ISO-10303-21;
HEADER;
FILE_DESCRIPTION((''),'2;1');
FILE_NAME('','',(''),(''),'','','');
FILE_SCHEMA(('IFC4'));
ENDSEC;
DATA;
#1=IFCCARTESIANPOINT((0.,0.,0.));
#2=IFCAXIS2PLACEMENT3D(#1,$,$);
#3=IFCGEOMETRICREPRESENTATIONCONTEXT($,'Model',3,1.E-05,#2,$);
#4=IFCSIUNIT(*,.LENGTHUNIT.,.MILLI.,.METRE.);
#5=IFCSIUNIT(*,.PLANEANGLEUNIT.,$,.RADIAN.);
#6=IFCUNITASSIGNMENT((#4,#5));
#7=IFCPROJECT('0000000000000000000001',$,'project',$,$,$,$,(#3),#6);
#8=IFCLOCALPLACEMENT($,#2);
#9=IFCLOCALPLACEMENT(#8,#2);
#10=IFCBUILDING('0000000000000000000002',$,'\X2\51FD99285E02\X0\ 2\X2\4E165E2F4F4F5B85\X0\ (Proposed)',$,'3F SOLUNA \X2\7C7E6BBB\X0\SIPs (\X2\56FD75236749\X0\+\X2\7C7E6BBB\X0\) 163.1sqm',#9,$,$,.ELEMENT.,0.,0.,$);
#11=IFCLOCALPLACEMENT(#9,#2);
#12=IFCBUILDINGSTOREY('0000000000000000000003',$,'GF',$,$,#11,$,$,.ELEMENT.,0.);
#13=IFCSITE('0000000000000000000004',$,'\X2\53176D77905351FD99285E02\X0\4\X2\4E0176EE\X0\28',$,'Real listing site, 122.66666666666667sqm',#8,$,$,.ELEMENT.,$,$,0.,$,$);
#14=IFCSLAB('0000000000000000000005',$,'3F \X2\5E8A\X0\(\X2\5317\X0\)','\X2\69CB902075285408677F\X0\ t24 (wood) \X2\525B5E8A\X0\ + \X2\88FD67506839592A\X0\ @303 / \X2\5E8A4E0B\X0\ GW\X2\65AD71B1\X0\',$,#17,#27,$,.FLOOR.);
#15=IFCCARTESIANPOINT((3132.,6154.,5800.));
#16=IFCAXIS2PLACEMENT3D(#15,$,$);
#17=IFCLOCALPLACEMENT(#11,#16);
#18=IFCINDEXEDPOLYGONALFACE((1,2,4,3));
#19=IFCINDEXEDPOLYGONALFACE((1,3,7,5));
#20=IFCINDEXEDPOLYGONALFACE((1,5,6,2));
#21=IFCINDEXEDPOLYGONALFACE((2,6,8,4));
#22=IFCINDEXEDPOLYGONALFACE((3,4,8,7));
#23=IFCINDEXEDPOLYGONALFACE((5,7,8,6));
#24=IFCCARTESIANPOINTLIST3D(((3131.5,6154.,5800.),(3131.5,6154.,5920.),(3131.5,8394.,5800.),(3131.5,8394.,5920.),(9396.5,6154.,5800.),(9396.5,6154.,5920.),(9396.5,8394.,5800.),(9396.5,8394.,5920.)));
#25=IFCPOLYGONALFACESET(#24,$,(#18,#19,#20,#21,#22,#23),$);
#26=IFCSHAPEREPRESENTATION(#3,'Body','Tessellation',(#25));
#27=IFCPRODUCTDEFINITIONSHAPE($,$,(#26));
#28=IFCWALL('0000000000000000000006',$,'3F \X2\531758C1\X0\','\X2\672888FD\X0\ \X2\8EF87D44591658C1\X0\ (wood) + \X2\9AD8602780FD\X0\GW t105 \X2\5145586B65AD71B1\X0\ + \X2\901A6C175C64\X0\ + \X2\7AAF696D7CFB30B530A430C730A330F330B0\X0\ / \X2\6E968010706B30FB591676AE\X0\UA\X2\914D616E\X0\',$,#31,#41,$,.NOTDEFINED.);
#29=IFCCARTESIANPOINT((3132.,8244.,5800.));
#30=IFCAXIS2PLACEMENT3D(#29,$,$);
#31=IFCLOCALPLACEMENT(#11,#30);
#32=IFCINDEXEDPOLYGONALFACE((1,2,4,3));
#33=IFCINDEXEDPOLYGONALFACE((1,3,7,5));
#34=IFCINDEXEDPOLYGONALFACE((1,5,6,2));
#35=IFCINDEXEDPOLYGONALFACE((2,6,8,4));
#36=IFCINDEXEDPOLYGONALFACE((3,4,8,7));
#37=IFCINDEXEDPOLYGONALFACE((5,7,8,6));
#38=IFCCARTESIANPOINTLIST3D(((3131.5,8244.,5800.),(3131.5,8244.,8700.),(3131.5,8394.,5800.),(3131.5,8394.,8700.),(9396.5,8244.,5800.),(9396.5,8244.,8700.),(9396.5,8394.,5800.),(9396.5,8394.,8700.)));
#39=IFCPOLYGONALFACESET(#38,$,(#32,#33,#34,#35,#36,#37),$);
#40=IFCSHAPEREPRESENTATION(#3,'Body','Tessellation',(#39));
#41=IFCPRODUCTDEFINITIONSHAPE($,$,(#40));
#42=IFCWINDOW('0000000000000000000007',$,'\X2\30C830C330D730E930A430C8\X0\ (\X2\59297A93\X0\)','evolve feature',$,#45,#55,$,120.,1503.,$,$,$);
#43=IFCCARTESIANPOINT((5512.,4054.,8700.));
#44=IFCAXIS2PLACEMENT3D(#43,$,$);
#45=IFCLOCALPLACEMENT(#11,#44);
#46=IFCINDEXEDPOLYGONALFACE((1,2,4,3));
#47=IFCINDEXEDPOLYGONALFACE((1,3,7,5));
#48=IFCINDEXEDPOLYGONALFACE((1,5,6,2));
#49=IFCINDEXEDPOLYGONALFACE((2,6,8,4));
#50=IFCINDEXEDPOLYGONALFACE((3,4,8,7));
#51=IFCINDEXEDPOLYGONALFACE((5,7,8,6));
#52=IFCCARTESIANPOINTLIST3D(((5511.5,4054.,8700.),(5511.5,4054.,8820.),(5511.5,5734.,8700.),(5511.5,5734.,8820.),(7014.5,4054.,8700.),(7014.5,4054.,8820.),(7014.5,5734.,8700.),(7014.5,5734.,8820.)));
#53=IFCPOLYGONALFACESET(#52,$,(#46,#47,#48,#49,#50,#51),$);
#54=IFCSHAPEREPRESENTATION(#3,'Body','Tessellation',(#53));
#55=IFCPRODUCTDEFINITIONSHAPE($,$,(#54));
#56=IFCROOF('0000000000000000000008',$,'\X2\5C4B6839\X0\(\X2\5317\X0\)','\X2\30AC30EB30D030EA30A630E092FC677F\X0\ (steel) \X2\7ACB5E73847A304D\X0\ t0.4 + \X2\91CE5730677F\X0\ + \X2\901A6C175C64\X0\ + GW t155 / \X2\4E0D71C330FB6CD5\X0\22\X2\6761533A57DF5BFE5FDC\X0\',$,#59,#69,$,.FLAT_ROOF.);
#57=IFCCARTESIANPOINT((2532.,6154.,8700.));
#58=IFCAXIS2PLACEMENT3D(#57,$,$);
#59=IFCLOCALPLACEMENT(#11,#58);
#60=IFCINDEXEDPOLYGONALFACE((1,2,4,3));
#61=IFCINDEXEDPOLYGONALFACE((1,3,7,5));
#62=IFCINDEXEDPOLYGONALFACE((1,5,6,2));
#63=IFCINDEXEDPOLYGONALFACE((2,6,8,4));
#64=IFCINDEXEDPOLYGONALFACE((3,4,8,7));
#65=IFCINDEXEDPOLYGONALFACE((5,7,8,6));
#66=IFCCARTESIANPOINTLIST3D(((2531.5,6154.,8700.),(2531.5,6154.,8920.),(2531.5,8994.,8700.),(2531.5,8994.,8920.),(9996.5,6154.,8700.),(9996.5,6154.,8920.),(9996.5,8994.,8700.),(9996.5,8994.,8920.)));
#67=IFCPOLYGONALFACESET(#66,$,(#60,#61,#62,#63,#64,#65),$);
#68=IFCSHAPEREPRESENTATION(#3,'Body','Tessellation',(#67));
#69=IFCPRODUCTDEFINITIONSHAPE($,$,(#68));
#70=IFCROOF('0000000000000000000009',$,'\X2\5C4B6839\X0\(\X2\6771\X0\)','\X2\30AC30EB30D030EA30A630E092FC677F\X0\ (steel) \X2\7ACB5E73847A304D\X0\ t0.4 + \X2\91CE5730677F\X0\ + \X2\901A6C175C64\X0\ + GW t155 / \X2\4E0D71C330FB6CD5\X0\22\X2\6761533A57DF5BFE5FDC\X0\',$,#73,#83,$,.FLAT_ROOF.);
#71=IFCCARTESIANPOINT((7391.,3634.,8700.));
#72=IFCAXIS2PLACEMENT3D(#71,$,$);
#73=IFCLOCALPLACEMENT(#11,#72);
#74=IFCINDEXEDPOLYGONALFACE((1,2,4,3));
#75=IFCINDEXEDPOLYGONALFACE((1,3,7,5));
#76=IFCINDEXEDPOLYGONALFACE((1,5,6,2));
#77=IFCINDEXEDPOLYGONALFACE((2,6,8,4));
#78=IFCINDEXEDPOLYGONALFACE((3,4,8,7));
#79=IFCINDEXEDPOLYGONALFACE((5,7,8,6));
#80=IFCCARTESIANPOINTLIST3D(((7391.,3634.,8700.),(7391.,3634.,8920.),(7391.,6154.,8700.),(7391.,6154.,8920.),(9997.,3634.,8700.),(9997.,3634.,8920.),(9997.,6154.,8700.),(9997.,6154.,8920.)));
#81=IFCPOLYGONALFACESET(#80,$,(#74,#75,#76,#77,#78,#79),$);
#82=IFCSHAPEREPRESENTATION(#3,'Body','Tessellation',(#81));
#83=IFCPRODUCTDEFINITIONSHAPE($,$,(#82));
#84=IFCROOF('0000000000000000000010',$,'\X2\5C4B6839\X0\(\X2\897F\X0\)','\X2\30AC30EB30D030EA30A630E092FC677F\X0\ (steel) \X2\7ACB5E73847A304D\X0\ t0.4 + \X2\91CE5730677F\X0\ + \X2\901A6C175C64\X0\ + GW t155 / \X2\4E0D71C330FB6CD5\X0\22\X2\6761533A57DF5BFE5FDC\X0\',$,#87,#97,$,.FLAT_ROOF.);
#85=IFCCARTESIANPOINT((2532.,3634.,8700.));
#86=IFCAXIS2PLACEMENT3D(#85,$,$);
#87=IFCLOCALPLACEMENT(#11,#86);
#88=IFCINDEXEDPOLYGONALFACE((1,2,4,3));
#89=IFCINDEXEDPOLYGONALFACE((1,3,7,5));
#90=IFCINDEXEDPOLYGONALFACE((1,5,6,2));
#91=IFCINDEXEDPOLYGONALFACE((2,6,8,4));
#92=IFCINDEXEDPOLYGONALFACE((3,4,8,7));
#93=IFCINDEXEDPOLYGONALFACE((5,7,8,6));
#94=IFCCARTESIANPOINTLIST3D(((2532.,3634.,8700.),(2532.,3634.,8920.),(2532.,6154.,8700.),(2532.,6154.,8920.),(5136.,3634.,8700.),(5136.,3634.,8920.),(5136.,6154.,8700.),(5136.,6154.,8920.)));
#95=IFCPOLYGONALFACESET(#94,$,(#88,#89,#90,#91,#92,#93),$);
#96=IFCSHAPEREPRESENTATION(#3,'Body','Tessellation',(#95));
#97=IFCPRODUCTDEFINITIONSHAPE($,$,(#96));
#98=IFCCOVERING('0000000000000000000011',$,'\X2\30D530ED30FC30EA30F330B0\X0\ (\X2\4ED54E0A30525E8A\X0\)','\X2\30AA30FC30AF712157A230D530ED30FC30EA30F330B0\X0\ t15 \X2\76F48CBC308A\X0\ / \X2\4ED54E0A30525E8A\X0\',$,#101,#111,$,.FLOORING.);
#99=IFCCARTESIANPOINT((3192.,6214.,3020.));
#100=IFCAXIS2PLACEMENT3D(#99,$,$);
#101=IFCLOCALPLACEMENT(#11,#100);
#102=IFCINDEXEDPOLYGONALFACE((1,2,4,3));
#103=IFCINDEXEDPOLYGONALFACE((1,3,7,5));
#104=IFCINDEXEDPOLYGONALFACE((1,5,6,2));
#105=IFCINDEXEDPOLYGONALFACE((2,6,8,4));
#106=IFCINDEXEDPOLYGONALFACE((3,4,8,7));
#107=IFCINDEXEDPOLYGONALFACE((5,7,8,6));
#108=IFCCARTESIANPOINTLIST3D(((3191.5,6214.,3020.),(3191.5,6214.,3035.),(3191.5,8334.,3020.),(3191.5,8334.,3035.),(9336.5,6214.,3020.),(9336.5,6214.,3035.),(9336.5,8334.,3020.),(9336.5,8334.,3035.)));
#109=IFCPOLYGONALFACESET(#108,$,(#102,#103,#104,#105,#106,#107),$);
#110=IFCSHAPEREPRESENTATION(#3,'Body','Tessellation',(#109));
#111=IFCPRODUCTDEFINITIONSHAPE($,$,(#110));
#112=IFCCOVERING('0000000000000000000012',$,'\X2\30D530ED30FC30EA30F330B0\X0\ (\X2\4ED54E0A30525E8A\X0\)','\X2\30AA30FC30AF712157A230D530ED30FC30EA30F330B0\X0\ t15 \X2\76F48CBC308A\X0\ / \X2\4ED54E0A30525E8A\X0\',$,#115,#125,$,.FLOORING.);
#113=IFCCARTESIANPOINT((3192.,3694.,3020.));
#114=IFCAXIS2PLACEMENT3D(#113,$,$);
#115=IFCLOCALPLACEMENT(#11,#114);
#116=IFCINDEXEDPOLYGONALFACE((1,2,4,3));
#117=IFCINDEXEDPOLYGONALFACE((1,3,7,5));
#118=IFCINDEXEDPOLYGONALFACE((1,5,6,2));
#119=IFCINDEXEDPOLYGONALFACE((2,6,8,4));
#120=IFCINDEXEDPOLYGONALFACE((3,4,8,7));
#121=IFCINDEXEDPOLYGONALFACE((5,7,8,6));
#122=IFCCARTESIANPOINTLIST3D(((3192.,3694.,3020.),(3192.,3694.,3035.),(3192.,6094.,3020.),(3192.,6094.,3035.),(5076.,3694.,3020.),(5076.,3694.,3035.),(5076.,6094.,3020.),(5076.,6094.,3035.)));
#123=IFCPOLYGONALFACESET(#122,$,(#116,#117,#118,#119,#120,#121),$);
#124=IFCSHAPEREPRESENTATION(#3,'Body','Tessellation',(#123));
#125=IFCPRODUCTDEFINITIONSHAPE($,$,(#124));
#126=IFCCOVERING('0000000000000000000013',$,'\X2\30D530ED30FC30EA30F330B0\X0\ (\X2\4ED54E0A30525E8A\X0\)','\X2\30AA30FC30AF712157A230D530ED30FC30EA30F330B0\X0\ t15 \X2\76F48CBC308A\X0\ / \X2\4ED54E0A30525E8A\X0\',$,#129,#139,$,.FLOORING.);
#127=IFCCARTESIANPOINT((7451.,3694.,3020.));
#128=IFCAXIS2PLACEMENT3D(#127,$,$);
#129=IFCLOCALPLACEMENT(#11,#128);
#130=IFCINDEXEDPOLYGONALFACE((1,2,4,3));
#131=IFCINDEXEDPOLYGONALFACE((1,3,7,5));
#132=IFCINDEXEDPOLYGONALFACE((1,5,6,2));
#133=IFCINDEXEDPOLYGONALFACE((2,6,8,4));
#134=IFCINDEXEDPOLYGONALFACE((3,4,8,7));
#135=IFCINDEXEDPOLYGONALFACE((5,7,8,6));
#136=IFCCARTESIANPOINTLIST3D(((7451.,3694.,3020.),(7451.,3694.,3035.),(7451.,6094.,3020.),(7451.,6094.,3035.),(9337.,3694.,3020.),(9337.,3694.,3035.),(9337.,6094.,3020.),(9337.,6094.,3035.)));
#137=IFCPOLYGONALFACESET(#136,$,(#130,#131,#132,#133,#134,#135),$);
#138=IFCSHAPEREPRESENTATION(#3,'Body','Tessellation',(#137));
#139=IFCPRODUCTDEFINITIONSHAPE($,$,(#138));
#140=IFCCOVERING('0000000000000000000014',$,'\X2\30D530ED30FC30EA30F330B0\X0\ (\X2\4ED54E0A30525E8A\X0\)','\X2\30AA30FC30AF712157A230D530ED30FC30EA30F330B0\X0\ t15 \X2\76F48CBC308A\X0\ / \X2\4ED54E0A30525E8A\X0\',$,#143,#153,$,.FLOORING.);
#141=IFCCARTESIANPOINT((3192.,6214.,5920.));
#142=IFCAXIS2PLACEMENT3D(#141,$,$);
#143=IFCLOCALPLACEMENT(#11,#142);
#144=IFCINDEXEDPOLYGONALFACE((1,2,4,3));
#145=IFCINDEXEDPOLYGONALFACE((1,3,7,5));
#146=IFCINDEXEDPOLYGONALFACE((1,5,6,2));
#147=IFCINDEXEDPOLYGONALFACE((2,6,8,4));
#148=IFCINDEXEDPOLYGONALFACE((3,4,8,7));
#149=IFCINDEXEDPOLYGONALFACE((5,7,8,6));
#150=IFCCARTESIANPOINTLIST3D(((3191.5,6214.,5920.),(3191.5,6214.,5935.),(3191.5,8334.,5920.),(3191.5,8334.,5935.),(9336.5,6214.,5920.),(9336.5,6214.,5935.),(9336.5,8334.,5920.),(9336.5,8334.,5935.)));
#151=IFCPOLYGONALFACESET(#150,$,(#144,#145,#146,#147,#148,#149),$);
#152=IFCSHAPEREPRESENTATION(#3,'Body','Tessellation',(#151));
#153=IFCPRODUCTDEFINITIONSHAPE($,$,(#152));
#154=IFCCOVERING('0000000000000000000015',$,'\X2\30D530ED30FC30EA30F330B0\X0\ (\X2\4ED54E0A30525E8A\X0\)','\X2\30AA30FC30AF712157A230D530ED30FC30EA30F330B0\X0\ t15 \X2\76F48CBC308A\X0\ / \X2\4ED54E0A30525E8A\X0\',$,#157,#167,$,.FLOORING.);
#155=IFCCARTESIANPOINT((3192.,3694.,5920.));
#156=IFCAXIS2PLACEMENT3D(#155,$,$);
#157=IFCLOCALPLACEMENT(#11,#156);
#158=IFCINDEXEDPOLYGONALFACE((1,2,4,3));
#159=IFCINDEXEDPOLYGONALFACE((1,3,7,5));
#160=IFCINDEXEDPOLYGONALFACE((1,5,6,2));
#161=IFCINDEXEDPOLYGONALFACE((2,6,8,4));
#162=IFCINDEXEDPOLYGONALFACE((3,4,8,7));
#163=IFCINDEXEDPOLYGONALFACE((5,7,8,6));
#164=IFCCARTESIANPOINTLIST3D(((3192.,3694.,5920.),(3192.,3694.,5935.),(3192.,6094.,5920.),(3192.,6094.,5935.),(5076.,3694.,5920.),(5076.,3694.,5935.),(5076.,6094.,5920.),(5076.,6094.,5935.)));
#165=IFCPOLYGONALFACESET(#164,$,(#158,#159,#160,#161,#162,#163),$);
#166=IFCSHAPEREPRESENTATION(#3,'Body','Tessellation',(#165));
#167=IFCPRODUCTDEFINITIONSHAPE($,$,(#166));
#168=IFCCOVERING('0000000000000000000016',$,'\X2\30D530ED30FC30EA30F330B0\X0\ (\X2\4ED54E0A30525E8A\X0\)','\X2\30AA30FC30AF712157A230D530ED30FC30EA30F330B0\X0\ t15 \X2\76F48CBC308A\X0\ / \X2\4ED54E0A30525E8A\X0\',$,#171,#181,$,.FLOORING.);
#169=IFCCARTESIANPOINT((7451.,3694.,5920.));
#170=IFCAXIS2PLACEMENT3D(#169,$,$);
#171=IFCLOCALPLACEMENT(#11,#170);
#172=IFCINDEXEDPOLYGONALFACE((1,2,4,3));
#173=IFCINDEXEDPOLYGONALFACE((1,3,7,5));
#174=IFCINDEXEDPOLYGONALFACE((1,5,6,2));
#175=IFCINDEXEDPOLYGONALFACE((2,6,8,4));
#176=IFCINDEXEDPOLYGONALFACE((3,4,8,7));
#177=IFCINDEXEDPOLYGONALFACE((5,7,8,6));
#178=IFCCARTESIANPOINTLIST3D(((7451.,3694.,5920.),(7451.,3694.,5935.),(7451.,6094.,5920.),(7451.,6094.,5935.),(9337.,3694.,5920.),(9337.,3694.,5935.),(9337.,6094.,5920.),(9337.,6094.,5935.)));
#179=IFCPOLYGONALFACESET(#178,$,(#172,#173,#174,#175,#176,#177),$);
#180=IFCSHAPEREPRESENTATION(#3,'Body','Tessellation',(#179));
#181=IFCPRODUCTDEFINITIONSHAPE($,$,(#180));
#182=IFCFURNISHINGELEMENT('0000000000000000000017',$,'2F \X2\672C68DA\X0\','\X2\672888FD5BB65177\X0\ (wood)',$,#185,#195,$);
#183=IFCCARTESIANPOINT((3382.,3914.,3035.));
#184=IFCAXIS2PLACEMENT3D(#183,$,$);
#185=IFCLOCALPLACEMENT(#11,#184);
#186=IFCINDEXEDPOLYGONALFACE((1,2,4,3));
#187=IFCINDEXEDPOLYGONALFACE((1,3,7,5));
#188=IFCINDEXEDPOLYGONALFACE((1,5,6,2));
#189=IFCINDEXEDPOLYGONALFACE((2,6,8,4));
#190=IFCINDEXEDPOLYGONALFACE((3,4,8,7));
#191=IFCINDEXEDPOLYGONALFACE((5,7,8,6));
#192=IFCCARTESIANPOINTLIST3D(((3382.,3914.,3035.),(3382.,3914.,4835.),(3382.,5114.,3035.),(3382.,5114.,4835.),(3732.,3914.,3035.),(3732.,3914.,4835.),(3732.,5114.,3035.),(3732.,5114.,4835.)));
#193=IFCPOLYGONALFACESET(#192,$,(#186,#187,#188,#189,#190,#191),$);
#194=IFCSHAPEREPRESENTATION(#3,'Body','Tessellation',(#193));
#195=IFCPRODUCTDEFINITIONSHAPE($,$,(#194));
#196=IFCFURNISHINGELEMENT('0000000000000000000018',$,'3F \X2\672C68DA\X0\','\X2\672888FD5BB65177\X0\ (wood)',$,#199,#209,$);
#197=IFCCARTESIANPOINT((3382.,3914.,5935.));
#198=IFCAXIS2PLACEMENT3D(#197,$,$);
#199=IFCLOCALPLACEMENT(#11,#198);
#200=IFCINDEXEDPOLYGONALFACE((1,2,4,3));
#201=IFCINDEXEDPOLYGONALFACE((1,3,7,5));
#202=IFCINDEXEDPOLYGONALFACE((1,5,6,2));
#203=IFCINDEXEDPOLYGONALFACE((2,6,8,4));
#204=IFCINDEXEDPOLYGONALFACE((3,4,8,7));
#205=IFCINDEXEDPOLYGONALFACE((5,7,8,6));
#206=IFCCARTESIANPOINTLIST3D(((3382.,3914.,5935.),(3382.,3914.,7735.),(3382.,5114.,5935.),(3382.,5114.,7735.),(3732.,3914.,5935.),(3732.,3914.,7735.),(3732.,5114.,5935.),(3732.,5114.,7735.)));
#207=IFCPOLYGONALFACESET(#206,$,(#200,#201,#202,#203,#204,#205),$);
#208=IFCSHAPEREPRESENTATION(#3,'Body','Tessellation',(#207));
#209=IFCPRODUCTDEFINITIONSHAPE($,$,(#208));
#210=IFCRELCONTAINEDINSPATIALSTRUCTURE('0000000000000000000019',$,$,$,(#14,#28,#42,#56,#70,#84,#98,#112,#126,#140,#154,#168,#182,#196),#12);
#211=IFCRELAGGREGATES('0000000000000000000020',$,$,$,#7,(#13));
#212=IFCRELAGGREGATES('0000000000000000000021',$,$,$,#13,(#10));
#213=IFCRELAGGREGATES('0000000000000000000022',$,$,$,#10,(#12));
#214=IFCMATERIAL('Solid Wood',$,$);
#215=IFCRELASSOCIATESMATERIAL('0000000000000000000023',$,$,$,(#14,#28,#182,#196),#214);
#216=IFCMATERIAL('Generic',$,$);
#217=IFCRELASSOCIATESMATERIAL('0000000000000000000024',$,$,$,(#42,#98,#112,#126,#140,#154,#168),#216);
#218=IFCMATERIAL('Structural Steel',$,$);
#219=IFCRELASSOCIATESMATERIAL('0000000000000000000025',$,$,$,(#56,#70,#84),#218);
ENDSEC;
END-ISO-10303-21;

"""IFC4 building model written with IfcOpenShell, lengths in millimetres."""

from ifc_helpers import new_model, si_unit, frame, frame_2d, origin, place, context, project, spatial, rectangle, extrude, material, element, save


model = new_model("IFC4")

# Units and contexts
model_context = context("Model", 3, precision=1e-05, world=origin())
ifc_project = project(units=[si_unit("LENGTHUNIT", "METRE", prefix="MILLI"), si_unit("PLANEANGLEUNIT", "RADIAN")], contexts=[model_context])

# Site, building, storey
site_placement = place(None, origin())
site = spatial("IfcSite", under=ifc_project, at=site_placement, Name="北海道函館市4丁目28", ObjectType="Real listing site, 122.66666666666667sqm", CompositionType="ELEMENT", RefElevation=0.0)
building_placement = place(site_placement, origin())
building = spatial("IfcBuilding", under=site, at=building_placement, Name="函館市 2世帯住宅 (Proposed)", ObjectType="3F SOLUNA 籾殻SIPs (国産杉+籾殻) 163.1sqm", CompositionType="ELEMENT", ElevationOfRefHeight=0.0, ElevationOfTerrain=0.0)
storey_placement = place(building_placement, origin())
storey = spatial("IfcBuildingStorey", under=building, at=storey_placement, Name="GF", CompositionType="ELEMENT", Elevation=0.0)

# Slab
ifc_material_1 = material(Name="Solid Wood")
slab_placement = place(storey_placement, frame((3132.0, 6154.0, 5800.0)))
element("IfcSlab", 1, at=slab_placement, inside=storey, material=ifc_material_1, Name="3F 床(北)", Description="構造用合板 t24 (wood) 剛床 + 製材根太 @303 / 床下 GW断熱", PredefinedType="FLOOR", context=model_context, shape_type="SweptSolid", body=[
    extrude(rectangle(XDim=6265.0, YDim=2240.0, at=frame_2d((3132.0, 1120.0))), frame((3132.0, 6154.0, 5800.0)), (0.0, 0.0, 1.0), 120.0),
])

# Wall
wall_1_placement = place(storey_placement, frame((3132.0, 8244.0, 5800.0)))
element("IfcWall", 2, at=wall_1_placement, inside=storey, material=ifc_material_1, Name="3F 北壁", Description="木製 軸組外壁 (wood) + 高性能GW t105 充填断熱 + 通気層 + 窯業系サイディング / 準耐火・外皮UA配慮", PredefinedType="NOTDEFINED", context=model_context, shape_type="SweptSolid", body=[
    extrude(rectangle(XDim=6265.0, YDim=150.0, at=frame_2d((3132.0, 75.0))), frame((3132.0, 8244.0, 5800.0)), (0.0, 0.0, 1.0), 2900.0),
])

# Window
ifc_material_2 = material(Name="Generic")
window_1_placement = place(storey_placement, frame((5512.0, 4054.0, 8700.0)))
element("IfcWindow", 3, at=window_1_placement, inside=storey, material=ifc_material_2, Name="トップライト (天窓)", Description="evolve feature", OverallHeight=120.0, OverallWidth=1503.0, context=model_context, shape_type="SweptSolid", body=[
    extrude(rectangle(XDim=1503.0, YDim=1680.0, at=frame_2d((751.0, 840.0))), frame((5512.0, 4054.0, 8700.0)), (0.0, 0.0, 1.0), 120.0),
])

# Roofs
ifc_material_3 = material(Name="Structural Steel")
roof_1_placement = place(storey_placement, frame((2532.0, 6154.0, 8700.0)))
element("IfcRoof", 4, at=roof_1_placement, inside=storey, material=ifc_material_3, Name="屋根(北)", Description="ガルバリウム鋼板 (steel) 立平葺き t0.4 + 野地板 + 通気層 + GW t155 / 不燃・法22条区域対応", PredefinedType="FLAT_ROOF", context=model_context, shape_type="SweptSolid", body=[
    extrude(rectangle(XDim=7465.0, YDim=2840.0, at=frame_2d((3732.0, 1420.0))), frame((2532.0, 6154.0, 8700.0)), (0.0, 0.0, 1.0), 220.0),
])
roof_2_placement = place(storey_placement, frame((7391.0, 3634.0, 8700.0)))
element("IfcRoof", 5, at=roof_2_placement, inside=storey, material=ifc_material_3, Name="屋根(東)", Description="ガルバリウム鋼板 (steel) 立平葺き t0.4 + 野地板 + 通気層 + GW t155 / 不燃・法22条区域対応", PredefinedType="FLAT_ROOF", context=model_context, shape_type="SweptSolid", body=[
    extrude(rectangle(XDim=2606.0, YDim=2520.0, at=frame_2d((1303.0, 1260.0))), frame((7391.0, 3634.0, 8700.0)), (0.0, 0.0, 1.0), 220.0),
])
roof_3_placement = place(storey_placement, frame((2532.0, 3634.0, 8700.0)))
element("IfcRoof", 6, at=roof_3_placement, inside=storey, material=ifc_material_3, Name="屋根(西)", Description="ガルバリウム鋼板 (steel) 立平葺き t0.4 + 野地板 + 通気層 + GW t155 / 不燃・法22条区域対応", PredefinedType="FLAT_ROOF", context=model_context, shape_type="SweptSolid", body=[
    extrude(rectangle(XDim=2604.0, YDim=2520.0, at=frame_2d((1302.0, 1260.0))), frame((2532.0, 3634.0, 8700.0)), (0.0, 0.0, 1.0), 220.0),
])

# Coverings
covering_1_placement = place(storey_placement, frame((3192.0, 6214.0, 3020.0)))
element("IfcCovering", 7, at=covering_1_placement, inside=storey, material=ifc_material_2, Name="フローリング (仕上げ床)", Description="オーク無垢フローリング t15 直貼り / 仕上げ床", PredefinedType="FLOORING", context=model_context, shape_type="SweptSolid", body=[
    extrude(rectangle(XDim=6145.0, YDim=2120.0, at=frame_2d((3072.0, 1060.0))), frame((3192.0, 6214.0, 3020.0)), (0.0, 0.0, 1.0), 15.0),
])
covering_2_placement = place(storey_placement, frame((3192.0, 3694.0, 3020.0)))
element("IfcCovering", 8, at=covering_2_placement, inside=storey, material=ifc_material_2, Name="フローリング (仕上げ床)", Description="オーク無垢フローリング t15 直貼り / 仕上げ床", PredefinedType="FLOORING", context=model_context, shape_type="SweptSolid", body=[
    extrude(rectangle(XDim=1884.0, YDim=2400.0, at=frame_2d((942.0, 1200.0))), frame((3192.0, 3694.0, 3020.0)), (0.0, 0.0, 1.0), 15.0),
])
covering_3_placement = place(storey_placement, frame((7451.0, 3694.0, 3020.0)))
element("IfcCovering", 9, at=covering_3_placement, inside=storey, material=ifc_material_2, Name="フローリング (仕上げ床)", Description="オーク無垢フローリング t15 直貼り / 仕上げ床", PredefinedType="FLOORING", context=model_context, shape_type="SweptSolid", body=[
    extrude(rectangle(XDim=1886.0, YDim=2400.0, at=frame_2d((943.0, 1200.0))), frame((7451.0, 3694.0, 3020.0)), (0.0, 0.0, 1.0), 15.0),
])
covering_4_placement = place(storey_placement, frame((3192.0, 6214.0, 5920.0)))
element("IfcCovering", 10, at=covering_4_placement, inside=storey, material=ifc_material_2, Name="フローリング (仕上げ床)", Description="オーク無垢フローリング t15 直貼り / 仕上げ床", PredefinedType="FLOORING", context=model_context, shape_type="SweptSolid", body=[
    extrude(rectangle(XDim=6145.0, YDim=2120.0, at=frame_2d((3072.0, 1060.0))), frame((3192.0, 6214.0, 5920.0)), (0.0, 0.0, 1.0), 15.0),
])
covering_5_placement = place(storey_placement, frame((3192.0, 3694.0, 5920.0)))
element("IfcCovering", 11, at=covering_5_placement, inside=storey, material=ifc_material_2, Name="フローリング (仕上げ床)", Description="オーク無垢フローリング t15 直貼り / 仕上げ床", PredefinedType="FLOORING", context=model_context, shape_type="SweptSolid", body=[
    extrude(rectangle(XDim=1884.0, YDim=2400.0, at=frame_2d((942.0, 1200.0))), frame((3192.0, 3694.0, 5920.0)), (0.0, 0.0, 1.0), 15.0),
])
covering_6_placement = place(storey_placement, frame((7451.0, 3694.0, 5920.0)))
element("IfcCovering", 12, at=covering_6_placement, inside=storey, material=ifc_material_2, Name="フローリング (仕上げ床)", Description="オーク無垢フローリング t15 直貼り / 仕上げ床", PredefinedType="FLOORING", context=model_context, shape_type="SweptSolid", body=[
    extrude(rectangle(XDim=1886.0, YDim=2400.0, at=frame_2d((943.0, 1200.0))), frame((7451.0, 3694.0, 5920.0)), (0.0, 0.0, 1.0), 15.0),
])

# Furnishing elements
furnishing_1_placement = place(storey_placement, frame((3382.0, 3914.0, 3035.0)))
element("IfcFurnishingElement", 13, at=furnishing_1_placement, inside=storey, material=ifc_material_1, Name="2F 本棚", Description="木製家具 (wood)", context=model_context, shape_type="SweptSolid", body=[
    extrude(rectangle(XDim=350.0, YDim=1200.0, at=frame_2d((175.0, 600.0))), frame((3382.0, 3914.0, 3035.0)), (0.0, 0.0, 1.0), 1800.0),
])
furnishing_2_placement = place(storey_placement, frame((3382.0, 3914.0, 5935.0)))
element("IfcFurnishingElement", 14, at=furnishing_2_placement, inside=storey, material=ifc_material_1, Name="3F 本棚", Description="木製家具 (wood)", context=model_context, shape_type="SweptSolid", body=[
    extrude(rectangle(XDim=350.0, YDim=1200.0, at=frame_2d((175.0, 600.0))), frame((3382.0, 3914.0, 5935.0)), (0.0, 0.0, 1.0), 1800.0),
])

save(model, "model.ifc")
